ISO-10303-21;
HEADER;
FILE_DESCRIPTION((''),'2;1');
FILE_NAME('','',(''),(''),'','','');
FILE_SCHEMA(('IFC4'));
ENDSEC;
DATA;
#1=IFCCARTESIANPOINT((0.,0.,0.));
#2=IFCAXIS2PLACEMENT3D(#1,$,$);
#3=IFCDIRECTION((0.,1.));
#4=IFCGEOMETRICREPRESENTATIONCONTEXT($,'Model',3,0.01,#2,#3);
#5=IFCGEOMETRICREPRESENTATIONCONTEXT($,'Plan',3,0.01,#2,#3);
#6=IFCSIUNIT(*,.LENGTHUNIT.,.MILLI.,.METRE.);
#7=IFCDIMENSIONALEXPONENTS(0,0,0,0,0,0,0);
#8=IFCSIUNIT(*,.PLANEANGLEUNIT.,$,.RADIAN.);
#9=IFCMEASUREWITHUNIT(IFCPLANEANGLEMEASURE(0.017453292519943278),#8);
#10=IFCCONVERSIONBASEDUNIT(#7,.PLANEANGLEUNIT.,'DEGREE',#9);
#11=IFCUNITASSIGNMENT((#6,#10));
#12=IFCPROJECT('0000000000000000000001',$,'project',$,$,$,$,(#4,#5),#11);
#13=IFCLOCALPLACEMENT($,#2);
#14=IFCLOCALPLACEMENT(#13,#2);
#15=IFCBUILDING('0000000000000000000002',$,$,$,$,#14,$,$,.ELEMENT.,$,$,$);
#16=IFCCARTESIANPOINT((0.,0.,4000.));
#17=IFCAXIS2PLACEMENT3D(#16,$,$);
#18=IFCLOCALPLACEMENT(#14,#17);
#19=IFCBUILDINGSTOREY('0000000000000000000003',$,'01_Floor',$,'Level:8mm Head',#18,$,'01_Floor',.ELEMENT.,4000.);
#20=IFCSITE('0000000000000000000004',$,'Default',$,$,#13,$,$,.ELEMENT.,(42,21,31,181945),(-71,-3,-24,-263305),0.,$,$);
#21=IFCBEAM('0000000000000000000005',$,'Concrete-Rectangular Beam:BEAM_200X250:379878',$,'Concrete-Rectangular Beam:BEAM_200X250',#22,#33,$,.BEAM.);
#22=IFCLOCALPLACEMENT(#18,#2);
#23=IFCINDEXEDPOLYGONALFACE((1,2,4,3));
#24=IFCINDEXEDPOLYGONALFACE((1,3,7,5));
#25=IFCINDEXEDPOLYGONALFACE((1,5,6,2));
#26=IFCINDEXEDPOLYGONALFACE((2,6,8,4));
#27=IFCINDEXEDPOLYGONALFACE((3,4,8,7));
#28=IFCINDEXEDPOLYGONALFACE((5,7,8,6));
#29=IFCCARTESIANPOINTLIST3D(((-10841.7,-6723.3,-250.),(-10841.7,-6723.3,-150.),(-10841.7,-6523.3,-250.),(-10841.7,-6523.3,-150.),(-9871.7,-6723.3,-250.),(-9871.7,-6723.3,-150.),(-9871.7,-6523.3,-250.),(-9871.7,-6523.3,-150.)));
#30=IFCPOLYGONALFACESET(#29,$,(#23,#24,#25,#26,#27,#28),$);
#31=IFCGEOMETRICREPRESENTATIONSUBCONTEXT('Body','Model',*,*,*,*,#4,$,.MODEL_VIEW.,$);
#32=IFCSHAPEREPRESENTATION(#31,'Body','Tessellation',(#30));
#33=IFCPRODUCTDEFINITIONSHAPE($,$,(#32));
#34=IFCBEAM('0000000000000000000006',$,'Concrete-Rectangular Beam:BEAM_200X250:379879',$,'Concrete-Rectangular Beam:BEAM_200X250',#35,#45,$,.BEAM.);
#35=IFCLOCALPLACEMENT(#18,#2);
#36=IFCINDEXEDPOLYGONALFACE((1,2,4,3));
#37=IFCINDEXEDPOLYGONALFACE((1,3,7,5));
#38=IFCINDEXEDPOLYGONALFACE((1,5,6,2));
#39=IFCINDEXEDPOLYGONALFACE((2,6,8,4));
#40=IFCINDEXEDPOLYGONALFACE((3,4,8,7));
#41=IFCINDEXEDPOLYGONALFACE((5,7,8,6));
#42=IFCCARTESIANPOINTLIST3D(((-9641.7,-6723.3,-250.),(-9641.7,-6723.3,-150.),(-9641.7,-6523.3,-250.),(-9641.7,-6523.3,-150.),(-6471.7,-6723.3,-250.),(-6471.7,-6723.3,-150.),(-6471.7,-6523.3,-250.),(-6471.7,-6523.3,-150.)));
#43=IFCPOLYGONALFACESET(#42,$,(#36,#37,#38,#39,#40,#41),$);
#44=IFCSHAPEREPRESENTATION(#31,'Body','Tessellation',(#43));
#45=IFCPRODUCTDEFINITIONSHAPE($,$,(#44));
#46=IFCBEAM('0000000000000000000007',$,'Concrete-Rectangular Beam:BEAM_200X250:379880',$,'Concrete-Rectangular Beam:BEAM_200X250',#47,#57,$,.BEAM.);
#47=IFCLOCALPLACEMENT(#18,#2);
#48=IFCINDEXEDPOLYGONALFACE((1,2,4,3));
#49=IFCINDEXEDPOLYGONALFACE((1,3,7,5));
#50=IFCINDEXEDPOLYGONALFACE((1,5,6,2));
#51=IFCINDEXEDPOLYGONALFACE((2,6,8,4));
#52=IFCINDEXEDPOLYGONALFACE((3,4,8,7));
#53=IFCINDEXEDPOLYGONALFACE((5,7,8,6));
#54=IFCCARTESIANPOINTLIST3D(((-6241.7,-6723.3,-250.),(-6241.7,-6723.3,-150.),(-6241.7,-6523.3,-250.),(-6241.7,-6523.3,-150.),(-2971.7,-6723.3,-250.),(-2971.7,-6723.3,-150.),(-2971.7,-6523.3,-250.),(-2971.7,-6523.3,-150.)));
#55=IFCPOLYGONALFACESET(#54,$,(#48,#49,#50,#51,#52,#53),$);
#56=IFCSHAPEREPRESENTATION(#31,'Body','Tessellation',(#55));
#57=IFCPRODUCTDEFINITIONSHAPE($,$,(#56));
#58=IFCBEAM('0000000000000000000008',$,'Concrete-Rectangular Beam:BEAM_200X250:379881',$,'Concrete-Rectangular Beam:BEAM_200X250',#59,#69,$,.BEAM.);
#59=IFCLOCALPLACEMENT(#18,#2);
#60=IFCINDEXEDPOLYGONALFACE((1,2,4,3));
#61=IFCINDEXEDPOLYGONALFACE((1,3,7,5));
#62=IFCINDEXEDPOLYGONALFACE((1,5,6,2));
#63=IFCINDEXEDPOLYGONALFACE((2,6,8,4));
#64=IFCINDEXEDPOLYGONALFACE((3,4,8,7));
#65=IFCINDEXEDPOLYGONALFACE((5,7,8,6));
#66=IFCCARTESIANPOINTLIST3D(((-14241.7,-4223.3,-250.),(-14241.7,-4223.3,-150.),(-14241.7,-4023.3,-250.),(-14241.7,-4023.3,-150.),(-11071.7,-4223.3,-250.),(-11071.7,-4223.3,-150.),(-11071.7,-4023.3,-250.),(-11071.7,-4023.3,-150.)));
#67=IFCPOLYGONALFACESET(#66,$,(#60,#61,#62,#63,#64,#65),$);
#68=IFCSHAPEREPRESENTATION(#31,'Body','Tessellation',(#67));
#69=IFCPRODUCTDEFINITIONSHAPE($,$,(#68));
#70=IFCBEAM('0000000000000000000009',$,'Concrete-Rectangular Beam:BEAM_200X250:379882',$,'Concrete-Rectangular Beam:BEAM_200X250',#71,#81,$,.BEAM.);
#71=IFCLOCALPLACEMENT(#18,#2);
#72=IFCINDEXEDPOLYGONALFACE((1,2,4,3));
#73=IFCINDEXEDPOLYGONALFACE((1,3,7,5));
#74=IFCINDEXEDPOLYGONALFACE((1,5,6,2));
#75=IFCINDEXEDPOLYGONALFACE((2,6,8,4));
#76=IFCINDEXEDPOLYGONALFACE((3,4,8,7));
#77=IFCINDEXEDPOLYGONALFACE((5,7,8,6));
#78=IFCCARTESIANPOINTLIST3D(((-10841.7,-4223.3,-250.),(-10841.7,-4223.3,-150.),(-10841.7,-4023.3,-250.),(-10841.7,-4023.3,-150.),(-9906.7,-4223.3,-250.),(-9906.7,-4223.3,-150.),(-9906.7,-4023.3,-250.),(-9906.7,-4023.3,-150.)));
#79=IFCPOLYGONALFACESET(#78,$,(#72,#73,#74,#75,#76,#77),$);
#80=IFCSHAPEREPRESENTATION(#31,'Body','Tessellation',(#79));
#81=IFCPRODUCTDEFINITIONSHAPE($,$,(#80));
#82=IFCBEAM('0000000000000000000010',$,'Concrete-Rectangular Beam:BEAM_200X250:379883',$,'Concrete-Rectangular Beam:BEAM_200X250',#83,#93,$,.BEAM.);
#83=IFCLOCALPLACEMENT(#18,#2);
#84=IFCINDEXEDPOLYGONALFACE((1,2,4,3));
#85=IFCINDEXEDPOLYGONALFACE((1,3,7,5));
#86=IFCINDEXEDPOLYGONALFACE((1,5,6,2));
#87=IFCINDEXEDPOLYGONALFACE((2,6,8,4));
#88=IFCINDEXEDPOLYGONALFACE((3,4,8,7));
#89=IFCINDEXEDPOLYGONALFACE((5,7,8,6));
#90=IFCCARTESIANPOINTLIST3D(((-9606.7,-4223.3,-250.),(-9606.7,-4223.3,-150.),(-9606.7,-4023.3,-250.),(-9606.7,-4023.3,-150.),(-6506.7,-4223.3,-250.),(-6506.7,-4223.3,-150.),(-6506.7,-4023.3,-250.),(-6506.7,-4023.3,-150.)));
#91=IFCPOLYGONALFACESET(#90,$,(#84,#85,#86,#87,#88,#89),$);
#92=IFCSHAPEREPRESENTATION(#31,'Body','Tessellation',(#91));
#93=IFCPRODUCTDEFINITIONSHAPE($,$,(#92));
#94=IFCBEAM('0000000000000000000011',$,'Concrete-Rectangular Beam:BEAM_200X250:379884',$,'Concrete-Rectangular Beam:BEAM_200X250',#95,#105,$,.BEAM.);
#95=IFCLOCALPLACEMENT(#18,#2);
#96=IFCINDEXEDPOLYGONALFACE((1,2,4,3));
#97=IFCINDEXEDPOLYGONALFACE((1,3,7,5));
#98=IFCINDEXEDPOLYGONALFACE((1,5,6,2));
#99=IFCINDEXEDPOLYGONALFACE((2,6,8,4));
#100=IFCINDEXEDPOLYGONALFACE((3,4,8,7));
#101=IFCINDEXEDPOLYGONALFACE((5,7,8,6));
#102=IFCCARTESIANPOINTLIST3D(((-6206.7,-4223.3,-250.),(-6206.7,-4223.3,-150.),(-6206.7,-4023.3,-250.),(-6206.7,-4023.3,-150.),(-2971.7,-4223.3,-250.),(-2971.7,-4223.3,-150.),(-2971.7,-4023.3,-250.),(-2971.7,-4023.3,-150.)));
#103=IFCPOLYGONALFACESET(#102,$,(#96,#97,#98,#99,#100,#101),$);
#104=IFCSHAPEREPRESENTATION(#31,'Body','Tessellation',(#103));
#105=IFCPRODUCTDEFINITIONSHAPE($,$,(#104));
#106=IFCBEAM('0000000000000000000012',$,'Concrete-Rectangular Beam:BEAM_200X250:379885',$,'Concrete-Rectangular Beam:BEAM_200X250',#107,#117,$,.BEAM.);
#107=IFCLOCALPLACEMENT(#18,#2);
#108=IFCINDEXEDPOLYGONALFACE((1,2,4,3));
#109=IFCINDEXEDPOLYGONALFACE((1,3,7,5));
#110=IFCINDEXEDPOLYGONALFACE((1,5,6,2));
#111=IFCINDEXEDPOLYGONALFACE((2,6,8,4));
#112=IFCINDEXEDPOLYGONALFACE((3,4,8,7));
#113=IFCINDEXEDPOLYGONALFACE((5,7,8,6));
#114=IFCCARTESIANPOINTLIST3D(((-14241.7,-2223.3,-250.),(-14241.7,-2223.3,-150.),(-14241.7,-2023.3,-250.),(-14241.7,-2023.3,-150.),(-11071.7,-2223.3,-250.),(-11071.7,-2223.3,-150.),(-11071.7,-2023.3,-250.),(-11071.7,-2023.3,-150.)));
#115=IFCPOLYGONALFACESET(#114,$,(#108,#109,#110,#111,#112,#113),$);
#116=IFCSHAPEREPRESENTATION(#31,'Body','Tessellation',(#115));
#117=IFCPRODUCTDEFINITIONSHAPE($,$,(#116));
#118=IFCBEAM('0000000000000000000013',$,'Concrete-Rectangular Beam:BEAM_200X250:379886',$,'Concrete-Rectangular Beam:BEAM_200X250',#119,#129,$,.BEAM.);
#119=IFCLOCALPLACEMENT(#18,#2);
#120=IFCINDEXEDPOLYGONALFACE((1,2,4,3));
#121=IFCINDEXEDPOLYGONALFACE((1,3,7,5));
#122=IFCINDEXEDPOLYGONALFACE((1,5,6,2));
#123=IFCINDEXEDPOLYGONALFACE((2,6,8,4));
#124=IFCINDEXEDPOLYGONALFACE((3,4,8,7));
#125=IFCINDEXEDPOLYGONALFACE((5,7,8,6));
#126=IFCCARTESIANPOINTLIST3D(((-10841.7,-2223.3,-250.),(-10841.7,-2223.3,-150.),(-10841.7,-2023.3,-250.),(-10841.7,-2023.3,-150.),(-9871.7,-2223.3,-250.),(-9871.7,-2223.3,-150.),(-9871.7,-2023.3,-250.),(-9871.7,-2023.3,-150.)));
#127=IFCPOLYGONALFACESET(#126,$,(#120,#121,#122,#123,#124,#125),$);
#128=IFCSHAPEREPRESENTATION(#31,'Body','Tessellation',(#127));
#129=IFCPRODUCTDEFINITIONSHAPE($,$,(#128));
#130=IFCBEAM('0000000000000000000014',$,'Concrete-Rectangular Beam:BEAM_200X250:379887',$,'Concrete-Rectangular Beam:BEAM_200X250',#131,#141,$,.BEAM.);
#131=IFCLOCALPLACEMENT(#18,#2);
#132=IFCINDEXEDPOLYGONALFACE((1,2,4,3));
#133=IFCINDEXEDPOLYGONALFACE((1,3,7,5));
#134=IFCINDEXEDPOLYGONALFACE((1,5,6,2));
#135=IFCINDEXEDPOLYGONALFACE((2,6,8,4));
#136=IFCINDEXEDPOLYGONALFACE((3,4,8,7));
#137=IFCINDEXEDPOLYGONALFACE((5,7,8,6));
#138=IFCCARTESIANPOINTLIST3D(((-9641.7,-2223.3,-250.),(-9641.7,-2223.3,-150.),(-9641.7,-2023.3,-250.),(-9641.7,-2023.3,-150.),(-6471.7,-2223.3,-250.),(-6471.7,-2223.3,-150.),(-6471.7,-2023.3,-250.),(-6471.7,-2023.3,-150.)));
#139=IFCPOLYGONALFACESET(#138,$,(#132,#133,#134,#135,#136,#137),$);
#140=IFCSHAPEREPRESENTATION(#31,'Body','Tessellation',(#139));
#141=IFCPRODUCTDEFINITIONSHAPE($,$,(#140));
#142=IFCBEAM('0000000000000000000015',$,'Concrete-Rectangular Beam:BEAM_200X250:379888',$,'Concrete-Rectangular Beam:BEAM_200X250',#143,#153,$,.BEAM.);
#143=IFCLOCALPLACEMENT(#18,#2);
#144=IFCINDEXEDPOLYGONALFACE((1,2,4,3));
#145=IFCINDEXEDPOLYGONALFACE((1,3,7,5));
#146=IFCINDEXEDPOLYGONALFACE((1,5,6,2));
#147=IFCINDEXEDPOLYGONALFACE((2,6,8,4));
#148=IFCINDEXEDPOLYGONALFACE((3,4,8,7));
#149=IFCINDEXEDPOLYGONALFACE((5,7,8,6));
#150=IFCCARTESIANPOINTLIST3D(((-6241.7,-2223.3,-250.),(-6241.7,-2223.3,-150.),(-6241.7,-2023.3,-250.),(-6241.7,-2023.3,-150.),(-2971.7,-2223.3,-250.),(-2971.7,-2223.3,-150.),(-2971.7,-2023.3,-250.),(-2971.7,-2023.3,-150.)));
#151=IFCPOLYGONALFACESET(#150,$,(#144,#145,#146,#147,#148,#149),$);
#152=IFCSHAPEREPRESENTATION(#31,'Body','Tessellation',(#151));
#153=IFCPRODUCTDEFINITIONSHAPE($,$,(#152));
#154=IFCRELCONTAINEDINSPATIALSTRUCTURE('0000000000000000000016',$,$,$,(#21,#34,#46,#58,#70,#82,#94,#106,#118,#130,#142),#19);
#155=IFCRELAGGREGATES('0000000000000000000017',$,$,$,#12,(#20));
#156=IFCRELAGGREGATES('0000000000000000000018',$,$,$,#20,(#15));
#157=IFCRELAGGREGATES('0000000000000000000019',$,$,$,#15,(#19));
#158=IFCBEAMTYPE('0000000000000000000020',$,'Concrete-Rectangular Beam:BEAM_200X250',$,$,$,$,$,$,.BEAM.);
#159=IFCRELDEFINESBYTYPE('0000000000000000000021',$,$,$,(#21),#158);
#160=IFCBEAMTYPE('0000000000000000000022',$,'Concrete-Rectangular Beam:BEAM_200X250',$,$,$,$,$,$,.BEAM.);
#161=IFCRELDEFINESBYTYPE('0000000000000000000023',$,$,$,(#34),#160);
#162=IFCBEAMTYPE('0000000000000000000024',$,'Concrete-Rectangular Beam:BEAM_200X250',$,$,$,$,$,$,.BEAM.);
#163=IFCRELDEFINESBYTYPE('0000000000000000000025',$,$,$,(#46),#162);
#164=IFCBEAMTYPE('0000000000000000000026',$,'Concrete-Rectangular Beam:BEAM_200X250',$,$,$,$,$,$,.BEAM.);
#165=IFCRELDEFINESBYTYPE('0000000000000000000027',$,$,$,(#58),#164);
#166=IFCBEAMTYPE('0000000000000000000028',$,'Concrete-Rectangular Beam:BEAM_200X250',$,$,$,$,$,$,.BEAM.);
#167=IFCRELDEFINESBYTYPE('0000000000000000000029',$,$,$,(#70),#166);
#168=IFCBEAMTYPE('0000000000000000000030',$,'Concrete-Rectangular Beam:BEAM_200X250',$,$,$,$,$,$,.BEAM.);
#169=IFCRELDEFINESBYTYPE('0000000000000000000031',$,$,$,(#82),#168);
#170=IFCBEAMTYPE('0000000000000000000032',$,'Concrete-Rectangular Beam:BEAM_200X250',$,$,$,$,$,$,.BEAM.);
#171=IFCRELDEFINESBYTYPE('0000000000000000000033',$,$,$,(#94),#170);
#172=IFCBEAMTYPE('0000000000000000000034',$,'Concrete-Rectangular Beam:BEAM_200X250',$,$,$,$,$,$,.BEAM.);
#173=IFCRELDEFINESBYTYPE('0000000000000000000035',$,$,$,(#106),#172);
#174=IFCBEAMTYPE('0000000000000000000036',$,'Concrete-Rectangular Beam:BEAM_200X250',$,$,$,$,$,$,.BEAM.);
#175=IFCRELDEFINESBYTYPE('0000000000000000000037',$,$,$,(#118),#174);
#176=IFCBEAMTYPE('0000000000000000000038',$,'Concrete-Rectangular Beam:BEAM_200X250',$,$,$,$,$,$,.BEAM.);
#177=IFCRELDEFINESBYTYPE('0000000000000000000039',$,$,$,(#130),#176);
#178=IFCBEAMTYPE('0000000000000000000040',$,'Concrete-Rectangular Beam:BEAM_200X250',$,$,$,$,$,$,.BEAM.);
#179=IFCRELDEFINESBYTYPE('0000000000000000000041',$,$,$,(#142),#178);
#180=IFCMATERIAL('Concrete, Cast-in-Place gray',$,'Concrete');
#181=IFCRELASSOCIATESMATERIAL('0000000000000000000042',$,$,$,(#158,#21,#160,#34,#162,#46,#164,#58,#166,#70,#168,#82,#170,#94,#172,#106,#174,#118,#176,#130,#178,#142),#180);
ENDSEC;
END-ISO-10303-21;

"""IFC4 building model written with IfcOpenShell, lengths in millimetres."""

from ifc_helpers import new_model, entity, si_unit, converted_unit, direction, frame, origin, place, context, subcontext, project, spatial, indexed_curve, outline, extrude, source, transform, mapped, material, type_object, type_shapes, element, save


model = new_model("IFC4")

# Units and contexts
model_context = context("Model", 3, precision=0.01, world=origin(), true_north=direction((0.0, 1.0)))
plan_context = context("Plan", 3, precision=0.01, world=origin(), true_north=direction((0.0, 1.0)))
body_context = subcontext(model_context, "Body", "Model", "MODEL_VIEW")
ifc_project = project(units=[si_unit("LENGTHUNIT", "METRE", prefix="MILLI"), converted_unit("PLANEANGLEUNIT", "DEGREE", entity("IfcPlaneAngleMeasure", 0.017453292519943278), si_unit("PLANEANGLEUNIT", "RADIAN"), dimensions=[0, 0, 0, 0, 0, 0, 0])], contexts=[model_context, plan_context])

# Site, building, storey
site_placement = place(None, origin())
site = spatial("IfcSite", under=ifc_project, at=site_placement, Name="Default", CompositionType="ELEMENT", RefLatitude=(42, 21, 31, 181945), RefLongitude=(-71, -3, -24, -263305), RefElevation=0.0)
building_placement = place(site_placement, origin())
building = spatial("IfcBuilding", under=site, at=building_placement, CompositionType="ELEMENT")
storey_placement = place(building_placement, frame((0.0, 0.0, 4000.0)))
storey = spatial("IfcBuildingStorey", under=building, at=storey_placement, Name="01_Floor", ObjectType="Level:8mm Head", LongName="01_Floor", CompositionType="ELEMENT", Elevation=4000.0)

# Beams
ifc_material = material(Name="Concrete, Cast-in-Place gray", Category="Concrete")
beam_type_1 = type_object("IfcBeamType", Name="Concrete-Rectangular Beam:BEAM_200X250", PredefinedType="BEAM", material=ifc_material)
shared_shape_1 = source(origin(), body_context, "Body", "SweptSolid", [
    extrude(outline(indexed_curve([(-50.0, -100.0), (50.0, -100.0), (50.0, 100.0), (-50.0, 100.0), (-50.0, -100.0)], self_intersect=False)), frame((-10841.7, -6623.3, 3800.0), z_axis=(1.0, 0.0, 0.0), x_axis=(0.0, 0.0, -1.0)), (0.0, 0.0, 1.0), 970.0),
])
type_shapes(beam_type_1, [shared_shape_1])
beam_1_placement = place(storey_placement, frame((0.0, 0.0, -4000.0)))
element("IfcBeam", 1, at=beam_1_placement, inside=storey, type_object=beam_type_1, material=ifc_material, Name="Concrete-Rectangular Beam:BEAM_200X250:379878", ObjectType="Concrete-Rectangular Beam:BEAM_200X250", PredefinedType="BEAM", context=body_context, shape_type="MappedRepresentation", body=[
    mapped(shared_shape_1, transform((0.0, 0.0, 0.0), scale=1.0)),
])
beam_type_2 = type_object("IfcBeamType", Name="Concrete-Rectangular Beam:BEAM_200X250", PredefinedType="BEAM", material=ifc_material)
shared_shape_2 = source(origin(), body_context, "Body", "SweptSolid", [
    extrude(outline(indexed_curve([(-50.0, -100.0), (50.0, -100.0), (50.0, 100.0), (-50.0, 100.0), (-50.0, -100.0)], self_intersect=False)), frame((-9641.7, -6623.3, 3800.0), z_axis=(1.0, 0.0, 0.0), x_axis=(0.0, 0.0, -1.0)), (0.0, 0.0, 1.0), 3170.0),
])
type_shapes(beam_type_2, [shared_shape_2])
beam_2_placement = place(storey_placement, frame((0.0, 0.0, -4000.0)))
element("IfcBeam", 2, at=beam_2_placement, inside=storey, type_object=beam_type_2, material=ifc_material, Name="Concrete-Rectangular Beam:BEAM_200X250:379879", ObjectType="Concrete-Rectangular Beam:BEAM_200X250", PredefinedType="BEAM", context=body_context, shape_type="MappedRepresentation", body=[
    mapped(shared_shape_2, transform((0.0, 0.0, 0.0), scale=1.0)),
])
beam_type_3 = type_object("IfcBeamType", Name="Concrete-Rectangular Beam:BEAM_200X250", PredefinedType="BEAM", material=ifc_material)
shared_shape_3 = source(origin(), body_context, "Body", "SweptSolid", [
    extrude(outline(indexed_curve([(-50.0, -100.0), (50.0, -100.0), (50.0, 100.0), (-50.0, 100.0), (-50.0, -100.0)], self_intersect=False)), frame((-6241.7, -6623.3, 3800.0), z_axis=(1.0, 0.0, 0.0), x_axis=(0.0, 0.0, -1.0)), (0.0, 0.0, 1.0), 3270.0),
])
type_shapes(beam_type_3, [shared_shape_3])
beam_3_placement = place(storey_placement, frame((0.0, 0.0, -4000.0)))
element("IfcBeam", 3, at=beam_3_placement, inside=storey, type_object=beam_type_3, material=ifc_material, Name="Concrete-Rectangular Beam:BEAM_200X250:379880", ObjectType="Concrete-Rectangular Beam:BEAM_200X250", PredefinedType="BEAM", context=body_context, shape_type="MappedRepresentation", body=[
    mapped(shared_shape_3, transform((0.0, 0.0, 0.0), scale=1.0)),
])
beam_type_4 = type_object("IfcBeamType", Name="Concrete-Rectangular Beam:BEAM_200X250", PredefinedType="BEAM", material=ifc_material)
shared_shape_4 = source(origin(), body_context, "Body", "SweptSolid", [
    extrude(outline(indexed_curve([(-50.0, -100.0), (50.0, -100.0), (50.0, 100.0), (-50.0, 100.0), (-50.0, -100.0)], self_intersect=False)), frame((-14241.7, -4123.3, 3800.0), z_axis=(1.0, 0.0, 0.0), x_axis=(0.0, 0.0, -1.0)), (0.0, 0.0, 1.0), 3170.0),
])
type_shapes(beam_type_4, [shared_shape_4])
beam_4_placement = place(storey_placement, frame((0.0, 0.0, -4000.0)))
element("IfcBeam", 4, at=beam_4_placement, inside=storey, type_object=beam_type_4, material=ifc_material, Name="Concrete-Rectangular Beam:BEAM_200X250:379881", ObjectType="Concrete-Rectangular Beam:BEAM_200X250", PredefinedType="BEAM", context=body_context, shape_type="MappedRepresentation", body=[
    mapped(shared_shape_4, transform((0.0, 0.0, 0.0), scale=1.0)),
])
beam_type_5 = type_object("IfcBeamType", Name="Concrete-Rectangular Beam:BEAM_200X250", PredefinedType="BEAM", material=ifc_material)
shared_shape_5 = source(origin(), body_context, "Body", "SweptSolid", [
    extrude(outline(indexed_curve([(-50.0, -100.0), (50.0, -100.0), (50.0, 100.0), (-50.0, 100.0), (-50.0, -100.0)], self_intersect=False)), frame((-10841.7, -4123.3, 3800.0), z_axis=(1.0, 0.0, 0.0), x_axis=(0.0, 0.0, -1.0)), (0.0, 0.0, 1.0), 935.0),
])
type_shapes(beam_type_5, [shared_shape_5])
beam_5_placement = place(storey_placement, frame((0.0, 0.0, -4000.0)))
element("IfcBeam", 5, at=beam_5_placement, inside=storey, type_object=beam_type_5, material=ifc_material, Name="Concrete-Rectangular Beam:BEAM_200X250:379882", ObjectType="Concrete-Rectangular Beam:BEAM_200X250", PredefinedType="BEAM", context=body_context, shape_type="MappedRepresentation", body=[
    mapped(shared_shape_5, transform((0.0, 0.0, 0.0), scale=1.0)),
])
beam_type_6 = type_object("IfcBeamType", Name="Concrete-Rectangular Beam:BEAM_200X250", PredefinedType="BEAM", material=ifc_material)
shared_shape_6 = source(origin(), body_context, "Body", "SweptSolid", [
    extrude(outline(indexed_curve([(-50.0, -100.0), (50.0, -100.0), (50.0, 100.0), (-50.0, 100.0), (-50.0, -100.0)], self_intersect=False)), frame((-9606.7, -4123.3, 3800.0), z_axis=(1.0, 0.0, 0.0), x_axis=(0.0, 0.0, -1.0)), (0.0, 0.0, 1.0), 3100.0),
])
type_shapes(beam_type_6, [shared_shape_6])
beam_6_placement = place(storey_placement, frame((0.0, 0.0, -4000.0)))
element("IfcBeam", 6, at=beam_6_placement, inside=storey, type_object=beam_type_6, material=ifc_material, Name="Concrete-Rectangular Beam:BEAM_200X250:379883", ObjectType="Concrete-Rectangular Beam:BEAM_200X250", PredefinedType="BEAM", context=body_context, shape_type="MappedRepresentation", body=[
    mapped(shared_shape_6, transform((0.0, 0.0, 0.0), scale=1.0)),
])
beam_type_7 = type_object("IfcBeamType", Name="Concrete-Rectangular Beam:BEAM_200X250", PredefinedType="BEAM", material=ifc_material)
shared_shape_7 = source(origin(), body_context, "Body", "SweptSolid", [
    extrude(outline(indexed_curve([(-50.0, -100.0), (50.0, -100.0), (50.0, 100.0), (-50.0, 100.0), (-50.0, -100.0)], self_intersect=False)), frame((-6206.7, -4123.3, 3800.0), z_axis=(1.0, 0.0, 0.0), x_axis=(0.0, 0.0, -1.0)), (0.0, 0.0, 1.0), 3235.0),
])
type_shapes(beam_type_7, [shared_shape_7])
beam_7_placement = place(storey_placement, frame((0.0, 0.0, -4000.0)))
element("IfcBeam", 7, at=beam_7_placement, inside=storey, type_object=beam_type_7, material=ifc_material, Name="Concrete-Rectangular Beam:BEAM_200X250:379884", ObjectType="Concrete-Rectangular Beam:BEAM_200X250", PredefinedType="BEAM", context=body_context, shape_type="MappedRepresentation", body=[
    mapped(shared_shape_7, transform((0.0, 0.0, 0.0), scale=1.0)),
])
beam_type_8 = type_object("IfcBeamType", Name="Concrete-Rectangular Beam:BEAM_200X250", PredefinedType="BEAM", material=ifc_material)
shared_shape_8 = source(origin(), body_context, "Body", "SweptSolid", [
    extrude(outline(indexed_curve([(-50.0, -100.0), (50.0, -100.0), (50.0, 100.0), (-50.0, 100.0), (-50.0, -100.0)], self_intersect=False)), frame((-14241.7, -2123.3, 3800.0), z_axis=(1.0, 0.0, 0.0), x_axis=(0.0, 0.0, -1.0)), (0.0, 0.0, 1.0), 3170.0),
])
type_shapes(beam_type_8, [shared_shape_8])
beam_8_placement = place(storey_placement, frame((0.0, 0.0, -4000.0)))
element("IfcBeam", 8, at=beam_8_placement, inside=storey, type_object=beam_type_8, material=ifc_material, Name="Concrete-Rectangular Beam:BEAM_200X250:379885", ObjectType="Concrete-Rectangular Beam:BEAM_200X250", PredefinedType="BEAM", context=body_context, shape_type="MappedRepresentation", body=[
    mapped(shared_shape_8, transform((0.0, 0.0, 0.0), scale=1.0)),
])
beam_type_9 = type_object("IfcBeamType", Name="Concrete-Rectangular Beam:BEAM_200X250", PredefinedType="BEAM", material=ifc_material)
shared_shape_9 = source(origin(), body_context, "Body", "SweptSolid", [
    extrude(outline(indexed_curve([(-50.0, -100.0), (50.0, -100.0), (50.0, 100.0), (-50.0, 100.0), (-50.0, -100.0)], self_intersect=False)), frame((-10841.7, -2123.3, 3800.0), z_axis=(1.0, 0.0, 0.0), x_axis=(0.0, 0.0, -1.0)), (0.0, 0.0, 1.0), 970.0),
])
type_shapes(beam_type_9, [shared_shape_9])
beam_9_placement = place(storey_placement, frame((0.0, 0.0, -4000.0)))
element("IfcBeam", 9, at=beam_9_placement, inside=storey, type_object=beam_type_9, material=ifc_material, Name="Concrete-Rectangular Beam:BEAM_200X250:379886", ObjectType="Concrete-Rectangular Beam:BEAM_200X250", PredefinedType="BEAM", context=body_context, shape_type="MappedRepresentation", body=[
    mapped(shared_shape_9, transform((0.0, 0.0, 0.0), scale=1.0)),
])
beam_type_10 = type_object("IfcBeamType", Name="Concrete-Rectangular Beam:BEAM_200X250", PredefinedType="BEAM", material=ifc_material)
shared_shape_10 = source(origin(), body_context, "Body", "SweptSolid", [
    extrude(outline(indexed_curve([(-50.0, -100.0), (50.0, -100.0), (50.0, 100.0), (-50.0, 100.0), (-50.0, -100.0)], self_intersect=False)), frame((-9641.7, -2123.3, 3800.0), z_axis=(1.0, 0.0, 0.0), x_axis=(0.0, 0.0, -1.0)), (0.0, 0.0, 1.0), 3170.0),
])
type_shapes(beam_type_10, [shared_shape_10])
beam_10_placement = place(storey_placement, frame((0.0, 0.0, -4000.0)))
element("IfcBeam", 10, at=beam_10_placement, inside=storey, type_object=beam_type_10, material=ifc_material, Name="Concrete-Rectangular Beam:BEAM_200X250:379887", ObjectType="Concrete-Rectangular Beam:BEAM_200X250", PredefinedType="BEAM", context=body_context, shape_type="MappedRepresentation", body=[
    mapped(shared_shape_10, transform((0.0, 0.0, 0.0), scale=1.0)),
])
beam_type_11 = type_object("IfcBeamType", Name="Concrete-Rectangular Beam:BEAM_200X250", PredefinedType="BEAM", material=ifc_material)
shared_shape_11 = source(origin(), body_context, "Body", "SweptSolid", [
    extrude(outline(indexed_curve([(-50.0, -100.0), (50.0, -100.0), (50.0, 100.0), (-50.0, 100.0), (-50.0, -100.0)], self_intersect=False)), frame((-6241.7, -2123.3, 3800.0), z_axis=(1.0, 0.0, 0.0), x_axis=(0.0, 0.0, -1.0)), (0.0, 0.0, 1.0), 3270.0),
])
type_shapes(beam_type_11, [shared_shape_11])
beam_11_placement = place(storey_placement, frame((0.0, 0.0, -4000.0)))
element("IfcBeam", 11, at=beam_11_placement, inside=storey, type_object=beam_type_11, material=ifc_material, Name="Concrete-Rectangular Beam:BEAM_200X250:379888", ObjectType="Concrete-Rectangular Beam:BEAM_200X250", PredefinedType="BEAM", context=body_context, shape_type="MappedRepresentation", body=[
    mapped(shared_shape_11, transform((0.0, 0.0, 0.0), scale=1.0)),
])

save(model, "model.ifc")
